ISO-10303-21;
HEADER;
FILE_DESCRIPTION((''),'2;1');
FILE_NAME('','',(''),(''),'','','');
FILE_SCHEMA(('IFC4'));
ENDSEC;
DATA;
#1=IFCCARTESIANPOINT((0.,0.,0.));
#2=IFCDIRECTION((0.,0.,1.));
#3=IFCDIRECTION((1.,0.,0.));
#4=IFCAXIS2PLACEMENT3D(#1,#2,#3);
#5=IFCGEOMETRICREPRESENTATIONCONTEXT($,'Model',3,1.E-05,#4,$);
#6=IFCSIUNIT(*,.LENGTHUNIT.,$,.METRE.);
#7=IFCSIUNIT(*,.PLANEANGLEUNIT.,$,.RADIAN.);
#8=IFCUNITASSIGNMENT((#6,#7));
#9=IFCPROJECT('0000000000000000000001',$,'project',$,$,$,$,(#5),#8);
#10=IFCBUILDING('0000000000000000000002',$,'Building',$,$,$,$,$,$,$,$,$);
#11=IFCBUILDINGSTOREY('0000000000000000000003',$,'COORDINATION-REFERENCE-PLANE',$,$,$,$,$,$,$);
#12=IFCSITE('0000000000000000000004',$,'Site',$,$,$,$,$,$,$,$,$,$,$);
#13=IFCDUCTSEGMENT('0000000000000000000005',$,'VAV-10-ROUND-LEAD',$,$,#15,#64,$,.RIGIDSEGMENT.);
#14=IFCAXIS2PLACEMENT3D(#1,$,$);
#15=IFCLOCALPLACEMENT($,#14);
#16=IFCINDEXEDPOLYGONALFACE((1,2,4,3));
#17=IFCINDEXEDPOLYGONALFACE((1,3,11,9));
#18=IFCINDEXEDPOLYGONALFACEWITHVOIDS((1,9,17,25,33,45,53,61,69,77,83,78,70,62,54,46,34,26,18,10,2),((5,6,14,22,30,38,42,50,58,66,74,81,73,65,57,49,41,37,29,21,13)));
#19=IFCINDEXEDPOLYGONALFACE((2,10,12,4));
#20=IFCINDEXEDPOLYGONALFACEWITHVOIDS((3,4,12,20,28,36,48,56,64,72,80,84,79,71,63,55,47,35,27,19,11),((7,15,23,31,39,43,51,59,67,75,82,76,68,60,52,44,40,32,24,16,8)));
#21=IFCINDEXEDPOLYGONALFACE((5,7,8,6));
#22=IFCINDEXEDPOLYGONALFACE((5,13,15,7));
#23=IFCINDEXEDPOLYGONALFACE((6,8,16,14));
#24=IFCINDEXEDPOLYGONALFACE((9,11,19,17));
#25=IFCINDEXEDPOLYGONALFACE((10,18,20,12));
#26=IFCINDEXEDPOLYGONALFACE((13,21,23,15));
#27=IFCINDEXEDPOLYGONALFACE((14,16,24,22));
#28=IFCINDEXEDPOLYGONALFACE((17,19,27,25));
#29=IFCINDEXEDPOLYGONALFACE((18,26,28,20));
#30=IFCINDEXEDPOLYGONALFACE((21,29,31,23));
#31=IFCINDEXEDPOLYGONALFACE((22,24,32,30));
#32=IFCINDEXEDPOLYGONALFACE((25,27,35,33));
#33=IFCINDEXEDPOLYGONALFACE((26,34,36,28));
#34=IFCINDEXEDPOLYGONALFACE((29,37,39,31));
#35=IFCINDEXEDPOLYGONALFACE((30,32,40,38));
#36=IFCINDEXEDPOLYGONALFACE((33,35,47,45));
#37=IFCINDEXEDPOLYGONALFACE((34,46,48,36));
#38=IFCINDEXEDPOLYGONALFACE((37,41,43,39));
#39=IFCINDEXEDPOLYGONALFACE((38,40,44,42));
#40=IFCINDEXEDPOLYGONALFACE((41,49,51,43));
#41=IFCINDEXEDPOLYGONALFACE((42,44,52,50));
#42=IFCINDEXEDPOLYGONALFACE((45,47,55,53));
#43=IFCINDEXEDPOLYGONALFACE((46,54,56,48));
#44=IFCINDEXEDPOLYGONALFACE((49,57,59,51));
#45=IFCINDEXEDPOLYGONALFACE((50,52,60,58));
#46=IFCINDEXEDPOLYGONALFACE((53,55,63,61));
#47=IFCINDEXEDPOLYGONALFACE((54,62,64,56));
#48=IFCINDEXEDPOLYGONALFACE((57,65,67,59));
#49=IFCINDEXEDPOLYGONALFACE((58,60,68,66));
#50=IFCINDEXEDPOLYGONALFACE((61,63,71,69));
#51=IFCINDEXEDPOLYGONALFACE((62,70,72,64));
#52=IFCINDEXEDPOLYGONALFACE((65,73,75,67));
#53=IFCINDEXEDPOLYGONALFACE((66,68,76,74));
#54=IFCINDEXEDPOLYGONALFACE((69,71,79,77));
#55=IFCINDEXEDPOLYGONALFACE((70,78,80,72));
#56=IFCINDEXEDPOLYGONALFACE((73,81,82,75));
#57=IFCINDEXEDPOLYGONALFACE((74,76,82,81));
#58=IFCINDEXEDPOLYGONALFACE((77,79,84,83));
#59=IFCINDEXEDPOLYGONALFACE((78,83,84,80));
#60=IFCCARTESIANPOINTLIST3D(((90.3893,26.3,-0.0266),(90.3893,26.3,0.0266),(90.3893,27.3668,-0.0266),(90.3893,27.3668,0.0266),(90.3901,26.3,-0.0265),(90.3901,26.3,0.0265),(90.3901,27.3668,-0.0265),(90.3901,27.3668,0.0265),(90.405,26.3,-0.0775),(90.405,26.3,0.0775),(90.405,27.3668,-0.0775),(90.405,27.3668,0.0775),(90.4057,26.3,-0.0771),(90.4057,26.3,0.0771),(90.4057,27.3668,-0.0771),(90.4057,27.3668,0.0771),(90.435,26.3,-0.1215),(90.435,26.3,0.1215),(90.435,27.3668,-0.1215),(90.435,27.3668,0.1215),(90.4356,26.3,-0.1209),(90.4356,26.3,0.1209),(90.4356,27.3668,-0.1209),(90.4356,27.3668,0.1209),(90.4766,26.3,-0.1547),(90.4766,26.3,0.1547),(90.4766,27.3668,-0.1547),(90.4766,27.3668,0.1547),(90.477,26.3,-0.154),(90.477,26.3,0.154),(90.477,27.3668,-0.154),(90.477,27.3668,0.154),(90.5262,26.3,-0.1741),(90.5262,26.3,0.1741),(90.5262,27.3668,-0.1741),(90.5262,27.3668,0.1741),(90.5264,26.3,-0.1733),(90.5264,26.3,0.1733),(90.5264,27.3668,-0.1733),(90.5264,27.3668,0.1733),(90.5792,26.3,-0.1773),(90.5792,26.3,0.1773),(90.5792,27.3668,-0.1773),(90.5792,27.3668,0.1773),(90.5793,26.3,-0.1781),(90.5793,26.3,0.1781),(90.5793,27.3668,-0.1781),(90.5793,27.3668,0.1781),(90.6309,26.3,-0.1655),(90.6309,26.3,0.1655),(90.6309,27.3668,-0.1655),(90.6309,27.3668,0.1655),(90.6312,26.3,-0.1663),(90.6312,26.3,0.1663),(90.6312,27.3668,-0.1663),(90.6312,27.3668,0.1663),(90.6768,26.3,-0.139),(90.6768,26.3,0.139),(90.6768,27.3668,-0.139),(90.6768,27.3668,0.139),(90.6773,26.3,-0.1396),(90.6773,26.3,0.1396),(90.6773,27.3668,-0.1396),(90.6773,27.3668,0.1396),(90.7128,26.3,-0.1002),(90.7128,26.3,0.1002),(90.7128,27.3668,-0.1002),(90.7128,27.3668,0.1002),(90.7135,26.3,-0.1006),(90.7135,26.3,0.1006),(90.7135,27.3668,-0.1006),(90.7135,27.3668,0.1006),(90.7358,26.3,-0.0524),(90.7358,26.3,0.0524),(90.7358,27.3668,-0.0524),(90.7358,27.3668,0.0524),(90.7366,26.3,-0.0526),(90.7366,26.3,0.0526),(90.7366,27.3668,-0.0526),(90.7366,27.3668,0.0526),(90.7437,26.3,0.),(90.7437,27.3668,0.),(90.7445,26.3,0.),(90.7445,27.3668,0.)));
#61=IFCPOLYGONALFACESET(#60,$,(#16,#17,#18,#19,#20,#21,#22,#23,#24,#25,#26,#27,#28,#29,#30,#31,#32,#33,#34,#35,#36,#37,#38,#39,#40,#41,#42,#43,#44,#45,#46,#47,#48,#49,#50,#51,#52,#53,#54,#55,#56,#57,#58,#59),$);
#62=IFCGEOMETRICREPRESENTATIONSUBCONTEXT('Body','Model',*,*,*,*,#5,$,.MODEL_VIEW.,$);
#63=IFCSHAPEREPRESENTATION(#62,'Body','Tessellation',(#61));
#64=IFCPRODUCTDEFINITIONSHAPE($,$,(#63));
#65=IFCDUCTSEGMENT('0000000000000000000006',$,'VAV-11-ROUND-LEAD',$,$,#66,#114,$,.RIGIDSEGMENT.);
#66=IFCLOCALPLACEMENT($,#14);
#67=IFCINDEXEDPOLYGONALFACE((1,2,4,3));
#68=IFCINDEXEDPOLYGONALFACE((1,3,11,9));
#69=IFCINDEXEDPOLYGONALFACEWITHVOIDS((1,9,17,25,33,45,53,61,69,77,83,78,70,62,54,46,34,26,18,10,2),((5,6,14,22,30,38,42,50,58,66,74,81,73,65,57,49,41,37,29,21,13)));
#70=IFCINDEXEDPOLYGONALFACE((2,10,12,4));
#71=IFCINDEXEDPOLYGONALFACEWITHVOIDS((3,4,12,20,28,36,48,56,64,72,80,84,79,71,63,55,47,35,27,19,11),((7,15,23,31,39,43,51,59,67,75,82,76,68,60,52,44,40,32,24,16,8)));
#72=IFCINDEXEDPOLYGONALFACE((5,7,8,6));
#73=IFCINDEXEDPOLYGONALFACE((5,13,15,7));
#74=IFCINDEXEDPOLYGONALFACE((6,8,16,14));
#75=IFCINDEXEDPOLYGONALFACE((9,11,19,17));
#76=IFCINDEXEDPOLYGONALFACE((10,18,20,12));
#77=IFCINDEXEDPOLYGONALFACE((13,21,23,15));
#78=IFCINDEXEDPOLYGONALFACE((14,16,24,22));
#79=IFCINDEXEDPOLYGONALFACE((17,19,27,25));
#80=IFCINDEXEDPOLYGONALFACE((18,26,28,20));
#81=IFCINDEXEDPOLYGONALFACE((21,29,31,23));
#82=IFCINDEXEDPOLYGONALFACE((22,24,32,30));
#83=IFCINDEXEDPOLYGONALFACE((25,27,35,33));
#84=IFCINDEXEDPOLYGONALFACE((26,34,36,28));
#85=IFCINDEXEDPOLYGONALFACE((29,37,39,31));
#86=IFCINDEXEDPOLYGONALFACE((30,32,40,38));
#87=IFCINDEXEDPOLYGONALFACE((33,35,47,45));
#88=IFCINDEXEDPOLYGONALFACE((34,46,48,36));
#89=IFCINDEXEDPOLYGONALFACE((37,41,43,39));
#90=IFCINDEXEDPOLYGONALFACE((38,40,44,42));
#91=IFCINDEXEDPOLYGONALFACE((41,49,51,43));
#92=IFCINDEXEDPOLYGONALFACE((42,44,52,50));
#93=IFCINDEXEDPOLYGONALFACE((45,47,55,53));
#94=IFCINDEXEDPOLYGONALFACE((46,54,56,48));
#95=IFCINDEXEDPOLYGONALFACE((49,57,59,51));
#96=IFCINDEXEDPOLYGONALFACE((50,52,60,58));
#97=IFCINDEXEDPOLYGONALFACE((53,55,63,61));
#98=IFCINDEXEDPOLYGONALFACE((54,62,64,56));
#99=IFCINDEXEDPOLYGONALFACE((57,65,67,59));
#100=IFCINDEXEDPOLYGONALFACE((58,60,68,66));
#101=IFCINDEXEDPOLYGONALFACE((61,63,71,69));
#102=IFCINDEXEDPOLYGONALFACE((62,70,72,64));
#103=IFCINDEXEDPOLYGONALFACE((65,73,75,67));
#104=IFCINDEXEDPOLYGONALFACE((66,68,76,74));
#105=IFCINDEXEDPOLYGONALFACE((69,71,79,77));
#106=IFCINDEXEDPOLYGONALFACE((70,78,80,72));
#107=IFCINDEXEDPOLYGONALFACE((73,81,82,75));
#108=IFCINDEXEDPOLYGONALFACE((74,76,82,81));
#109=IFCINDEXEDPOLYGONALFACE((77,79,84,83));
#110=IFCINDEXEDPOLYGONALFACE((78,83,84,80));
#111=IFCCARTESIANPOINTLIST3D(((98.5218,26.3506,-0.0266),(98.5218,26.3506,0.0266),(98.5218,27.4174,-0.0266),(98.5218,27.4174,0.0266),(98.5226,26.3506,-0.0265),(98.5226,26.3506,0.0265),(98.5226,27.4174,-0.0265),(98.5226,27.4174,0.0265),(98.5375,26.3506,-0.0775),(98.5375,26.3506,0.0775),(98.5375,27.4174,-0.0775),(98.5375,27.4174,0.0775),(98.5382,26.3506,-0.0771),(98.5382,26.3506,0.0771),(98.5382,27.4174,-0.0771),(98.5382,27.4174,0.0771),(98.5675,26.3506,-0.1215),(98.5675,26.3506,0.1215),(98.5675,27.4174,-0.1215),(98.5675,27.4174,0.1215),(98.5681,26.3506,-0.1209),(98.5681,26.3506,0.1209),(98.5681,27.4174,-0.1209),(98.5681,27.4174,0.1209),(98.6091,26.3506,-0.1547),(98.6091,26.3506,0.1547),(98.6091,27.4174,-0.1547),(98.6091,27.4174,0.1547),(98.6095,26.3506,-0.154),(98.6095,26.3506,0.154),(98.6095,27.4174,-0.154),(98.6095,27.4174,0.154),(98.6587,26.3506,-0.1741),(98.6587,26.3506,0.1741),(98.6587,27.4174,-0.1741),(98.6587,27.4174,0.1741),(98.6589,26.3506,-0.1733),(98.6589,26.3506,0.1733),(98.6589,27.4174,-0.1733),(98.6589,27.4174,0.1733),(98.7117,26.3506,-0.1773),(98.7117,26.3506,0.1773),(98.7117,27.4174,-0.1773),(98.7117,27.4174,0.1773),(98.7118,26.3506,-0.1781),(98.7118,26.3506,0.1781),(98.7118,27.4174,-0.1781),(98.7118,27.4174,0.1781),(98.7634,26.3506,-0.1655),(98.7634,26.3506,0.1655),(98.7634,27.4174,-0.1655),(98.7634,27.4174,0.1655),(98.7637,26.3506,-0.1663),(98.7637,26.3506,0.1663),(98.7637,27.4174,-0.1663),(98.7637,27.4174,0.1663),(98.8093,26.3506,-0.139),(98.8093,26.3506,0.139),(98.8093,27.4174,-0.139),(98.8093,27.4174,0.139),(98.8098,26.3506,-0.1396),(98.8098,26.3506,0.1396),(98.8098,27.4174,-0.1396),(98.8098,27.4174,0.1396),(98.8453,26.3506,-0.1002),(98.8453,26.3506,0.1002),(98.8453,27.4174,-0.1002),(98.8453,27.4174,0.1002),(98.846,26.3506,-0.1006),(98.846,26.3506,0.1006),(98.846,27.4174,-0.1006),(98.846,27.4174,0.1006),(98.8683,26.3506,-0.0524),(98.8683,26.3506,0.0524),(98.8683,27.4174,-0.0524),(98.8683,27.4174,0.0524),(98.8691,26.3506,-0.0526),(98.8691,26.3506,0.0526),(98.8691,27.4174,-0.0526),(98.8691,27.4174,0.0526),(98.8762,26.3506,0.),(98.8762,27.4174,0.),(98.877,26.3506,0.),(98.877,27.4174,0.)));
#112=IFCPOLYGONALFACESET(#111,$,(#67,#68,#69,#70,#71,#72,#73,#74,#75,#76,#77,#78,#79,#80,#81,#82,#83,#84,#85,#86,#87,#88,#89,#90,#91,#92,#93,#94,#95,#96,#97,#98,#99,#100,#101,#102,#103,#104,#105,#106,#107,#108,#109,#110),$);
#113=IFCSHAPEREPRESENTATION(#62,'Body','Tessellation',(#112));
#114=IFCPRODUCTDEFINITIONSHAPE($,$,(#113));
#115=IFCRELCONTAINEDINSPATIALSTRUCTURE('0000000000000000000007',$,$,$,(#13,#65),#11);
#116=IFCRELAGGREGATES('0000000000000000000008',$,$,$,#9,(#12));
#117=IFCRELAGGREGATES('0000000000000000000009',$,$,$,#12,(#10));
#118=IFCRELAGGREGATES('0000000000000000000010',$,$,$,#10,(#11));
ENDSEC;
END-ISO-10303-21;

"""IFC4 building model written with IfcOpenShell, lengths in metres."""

from ifc_helpers import new_model, si_unit, frame, origin, origin_with_axes, place, context, subcontext, project, spatial, hollow_circle, extrude, element, save


model = new_model("IFC4")

# Units and contexts
model_context = context("Model", 3, precision=1e-05, world=origin_with_axes())
body_context_1 = subcontext(model_context, "Body", "Model", "MODEL_VIEW")
ifc_project = project(units=[si_unit("LENGTHUNIT", "METRE"), si_unit("PLANEANGLEUNIT", "RADIAN")], contexts=[model_context])

# Site, building, storey
site = spatial("IfcSite", under=ifc_project, Name="Site")
building = spatial("IfcBuilding", under=site, Name="Building")
storey = spatial("IfcBuildingStorey", under=building, Name="COORDINATION-REFERENCE-PLANE")

# Duct segments
for number, where, z_axis, x_axis, name in (
    (1, (90.5659, 27.3668, 0.0), (0.0, -1.0, 0.0), (1.0, 0.0, 0.0), "VAV-10-ROUND-LEAD"),
    (2, (98.6984, 27.4174, 0.0), (0.0, -1.0, 0.0), (1.0, 0.0, 0.0), "VAV-11-ROUND-LEAD"),
):
    element("IfcDuctSegment", number, at=place(None, frame(where, z_axis=z_axis, x_axis=x_axis)), inside=storey, Name=name, PredefinedType="RIGIDSEGMENT", context=body_context_1, shape_type="SweptSolid", body=[
        extrude(hollow_circle(Radius=0.1786, WallThickness=0.0008), origin(), (0.0, 0.0, 1.0), 1.0668),
    ])

save(model, "model.ifc")
